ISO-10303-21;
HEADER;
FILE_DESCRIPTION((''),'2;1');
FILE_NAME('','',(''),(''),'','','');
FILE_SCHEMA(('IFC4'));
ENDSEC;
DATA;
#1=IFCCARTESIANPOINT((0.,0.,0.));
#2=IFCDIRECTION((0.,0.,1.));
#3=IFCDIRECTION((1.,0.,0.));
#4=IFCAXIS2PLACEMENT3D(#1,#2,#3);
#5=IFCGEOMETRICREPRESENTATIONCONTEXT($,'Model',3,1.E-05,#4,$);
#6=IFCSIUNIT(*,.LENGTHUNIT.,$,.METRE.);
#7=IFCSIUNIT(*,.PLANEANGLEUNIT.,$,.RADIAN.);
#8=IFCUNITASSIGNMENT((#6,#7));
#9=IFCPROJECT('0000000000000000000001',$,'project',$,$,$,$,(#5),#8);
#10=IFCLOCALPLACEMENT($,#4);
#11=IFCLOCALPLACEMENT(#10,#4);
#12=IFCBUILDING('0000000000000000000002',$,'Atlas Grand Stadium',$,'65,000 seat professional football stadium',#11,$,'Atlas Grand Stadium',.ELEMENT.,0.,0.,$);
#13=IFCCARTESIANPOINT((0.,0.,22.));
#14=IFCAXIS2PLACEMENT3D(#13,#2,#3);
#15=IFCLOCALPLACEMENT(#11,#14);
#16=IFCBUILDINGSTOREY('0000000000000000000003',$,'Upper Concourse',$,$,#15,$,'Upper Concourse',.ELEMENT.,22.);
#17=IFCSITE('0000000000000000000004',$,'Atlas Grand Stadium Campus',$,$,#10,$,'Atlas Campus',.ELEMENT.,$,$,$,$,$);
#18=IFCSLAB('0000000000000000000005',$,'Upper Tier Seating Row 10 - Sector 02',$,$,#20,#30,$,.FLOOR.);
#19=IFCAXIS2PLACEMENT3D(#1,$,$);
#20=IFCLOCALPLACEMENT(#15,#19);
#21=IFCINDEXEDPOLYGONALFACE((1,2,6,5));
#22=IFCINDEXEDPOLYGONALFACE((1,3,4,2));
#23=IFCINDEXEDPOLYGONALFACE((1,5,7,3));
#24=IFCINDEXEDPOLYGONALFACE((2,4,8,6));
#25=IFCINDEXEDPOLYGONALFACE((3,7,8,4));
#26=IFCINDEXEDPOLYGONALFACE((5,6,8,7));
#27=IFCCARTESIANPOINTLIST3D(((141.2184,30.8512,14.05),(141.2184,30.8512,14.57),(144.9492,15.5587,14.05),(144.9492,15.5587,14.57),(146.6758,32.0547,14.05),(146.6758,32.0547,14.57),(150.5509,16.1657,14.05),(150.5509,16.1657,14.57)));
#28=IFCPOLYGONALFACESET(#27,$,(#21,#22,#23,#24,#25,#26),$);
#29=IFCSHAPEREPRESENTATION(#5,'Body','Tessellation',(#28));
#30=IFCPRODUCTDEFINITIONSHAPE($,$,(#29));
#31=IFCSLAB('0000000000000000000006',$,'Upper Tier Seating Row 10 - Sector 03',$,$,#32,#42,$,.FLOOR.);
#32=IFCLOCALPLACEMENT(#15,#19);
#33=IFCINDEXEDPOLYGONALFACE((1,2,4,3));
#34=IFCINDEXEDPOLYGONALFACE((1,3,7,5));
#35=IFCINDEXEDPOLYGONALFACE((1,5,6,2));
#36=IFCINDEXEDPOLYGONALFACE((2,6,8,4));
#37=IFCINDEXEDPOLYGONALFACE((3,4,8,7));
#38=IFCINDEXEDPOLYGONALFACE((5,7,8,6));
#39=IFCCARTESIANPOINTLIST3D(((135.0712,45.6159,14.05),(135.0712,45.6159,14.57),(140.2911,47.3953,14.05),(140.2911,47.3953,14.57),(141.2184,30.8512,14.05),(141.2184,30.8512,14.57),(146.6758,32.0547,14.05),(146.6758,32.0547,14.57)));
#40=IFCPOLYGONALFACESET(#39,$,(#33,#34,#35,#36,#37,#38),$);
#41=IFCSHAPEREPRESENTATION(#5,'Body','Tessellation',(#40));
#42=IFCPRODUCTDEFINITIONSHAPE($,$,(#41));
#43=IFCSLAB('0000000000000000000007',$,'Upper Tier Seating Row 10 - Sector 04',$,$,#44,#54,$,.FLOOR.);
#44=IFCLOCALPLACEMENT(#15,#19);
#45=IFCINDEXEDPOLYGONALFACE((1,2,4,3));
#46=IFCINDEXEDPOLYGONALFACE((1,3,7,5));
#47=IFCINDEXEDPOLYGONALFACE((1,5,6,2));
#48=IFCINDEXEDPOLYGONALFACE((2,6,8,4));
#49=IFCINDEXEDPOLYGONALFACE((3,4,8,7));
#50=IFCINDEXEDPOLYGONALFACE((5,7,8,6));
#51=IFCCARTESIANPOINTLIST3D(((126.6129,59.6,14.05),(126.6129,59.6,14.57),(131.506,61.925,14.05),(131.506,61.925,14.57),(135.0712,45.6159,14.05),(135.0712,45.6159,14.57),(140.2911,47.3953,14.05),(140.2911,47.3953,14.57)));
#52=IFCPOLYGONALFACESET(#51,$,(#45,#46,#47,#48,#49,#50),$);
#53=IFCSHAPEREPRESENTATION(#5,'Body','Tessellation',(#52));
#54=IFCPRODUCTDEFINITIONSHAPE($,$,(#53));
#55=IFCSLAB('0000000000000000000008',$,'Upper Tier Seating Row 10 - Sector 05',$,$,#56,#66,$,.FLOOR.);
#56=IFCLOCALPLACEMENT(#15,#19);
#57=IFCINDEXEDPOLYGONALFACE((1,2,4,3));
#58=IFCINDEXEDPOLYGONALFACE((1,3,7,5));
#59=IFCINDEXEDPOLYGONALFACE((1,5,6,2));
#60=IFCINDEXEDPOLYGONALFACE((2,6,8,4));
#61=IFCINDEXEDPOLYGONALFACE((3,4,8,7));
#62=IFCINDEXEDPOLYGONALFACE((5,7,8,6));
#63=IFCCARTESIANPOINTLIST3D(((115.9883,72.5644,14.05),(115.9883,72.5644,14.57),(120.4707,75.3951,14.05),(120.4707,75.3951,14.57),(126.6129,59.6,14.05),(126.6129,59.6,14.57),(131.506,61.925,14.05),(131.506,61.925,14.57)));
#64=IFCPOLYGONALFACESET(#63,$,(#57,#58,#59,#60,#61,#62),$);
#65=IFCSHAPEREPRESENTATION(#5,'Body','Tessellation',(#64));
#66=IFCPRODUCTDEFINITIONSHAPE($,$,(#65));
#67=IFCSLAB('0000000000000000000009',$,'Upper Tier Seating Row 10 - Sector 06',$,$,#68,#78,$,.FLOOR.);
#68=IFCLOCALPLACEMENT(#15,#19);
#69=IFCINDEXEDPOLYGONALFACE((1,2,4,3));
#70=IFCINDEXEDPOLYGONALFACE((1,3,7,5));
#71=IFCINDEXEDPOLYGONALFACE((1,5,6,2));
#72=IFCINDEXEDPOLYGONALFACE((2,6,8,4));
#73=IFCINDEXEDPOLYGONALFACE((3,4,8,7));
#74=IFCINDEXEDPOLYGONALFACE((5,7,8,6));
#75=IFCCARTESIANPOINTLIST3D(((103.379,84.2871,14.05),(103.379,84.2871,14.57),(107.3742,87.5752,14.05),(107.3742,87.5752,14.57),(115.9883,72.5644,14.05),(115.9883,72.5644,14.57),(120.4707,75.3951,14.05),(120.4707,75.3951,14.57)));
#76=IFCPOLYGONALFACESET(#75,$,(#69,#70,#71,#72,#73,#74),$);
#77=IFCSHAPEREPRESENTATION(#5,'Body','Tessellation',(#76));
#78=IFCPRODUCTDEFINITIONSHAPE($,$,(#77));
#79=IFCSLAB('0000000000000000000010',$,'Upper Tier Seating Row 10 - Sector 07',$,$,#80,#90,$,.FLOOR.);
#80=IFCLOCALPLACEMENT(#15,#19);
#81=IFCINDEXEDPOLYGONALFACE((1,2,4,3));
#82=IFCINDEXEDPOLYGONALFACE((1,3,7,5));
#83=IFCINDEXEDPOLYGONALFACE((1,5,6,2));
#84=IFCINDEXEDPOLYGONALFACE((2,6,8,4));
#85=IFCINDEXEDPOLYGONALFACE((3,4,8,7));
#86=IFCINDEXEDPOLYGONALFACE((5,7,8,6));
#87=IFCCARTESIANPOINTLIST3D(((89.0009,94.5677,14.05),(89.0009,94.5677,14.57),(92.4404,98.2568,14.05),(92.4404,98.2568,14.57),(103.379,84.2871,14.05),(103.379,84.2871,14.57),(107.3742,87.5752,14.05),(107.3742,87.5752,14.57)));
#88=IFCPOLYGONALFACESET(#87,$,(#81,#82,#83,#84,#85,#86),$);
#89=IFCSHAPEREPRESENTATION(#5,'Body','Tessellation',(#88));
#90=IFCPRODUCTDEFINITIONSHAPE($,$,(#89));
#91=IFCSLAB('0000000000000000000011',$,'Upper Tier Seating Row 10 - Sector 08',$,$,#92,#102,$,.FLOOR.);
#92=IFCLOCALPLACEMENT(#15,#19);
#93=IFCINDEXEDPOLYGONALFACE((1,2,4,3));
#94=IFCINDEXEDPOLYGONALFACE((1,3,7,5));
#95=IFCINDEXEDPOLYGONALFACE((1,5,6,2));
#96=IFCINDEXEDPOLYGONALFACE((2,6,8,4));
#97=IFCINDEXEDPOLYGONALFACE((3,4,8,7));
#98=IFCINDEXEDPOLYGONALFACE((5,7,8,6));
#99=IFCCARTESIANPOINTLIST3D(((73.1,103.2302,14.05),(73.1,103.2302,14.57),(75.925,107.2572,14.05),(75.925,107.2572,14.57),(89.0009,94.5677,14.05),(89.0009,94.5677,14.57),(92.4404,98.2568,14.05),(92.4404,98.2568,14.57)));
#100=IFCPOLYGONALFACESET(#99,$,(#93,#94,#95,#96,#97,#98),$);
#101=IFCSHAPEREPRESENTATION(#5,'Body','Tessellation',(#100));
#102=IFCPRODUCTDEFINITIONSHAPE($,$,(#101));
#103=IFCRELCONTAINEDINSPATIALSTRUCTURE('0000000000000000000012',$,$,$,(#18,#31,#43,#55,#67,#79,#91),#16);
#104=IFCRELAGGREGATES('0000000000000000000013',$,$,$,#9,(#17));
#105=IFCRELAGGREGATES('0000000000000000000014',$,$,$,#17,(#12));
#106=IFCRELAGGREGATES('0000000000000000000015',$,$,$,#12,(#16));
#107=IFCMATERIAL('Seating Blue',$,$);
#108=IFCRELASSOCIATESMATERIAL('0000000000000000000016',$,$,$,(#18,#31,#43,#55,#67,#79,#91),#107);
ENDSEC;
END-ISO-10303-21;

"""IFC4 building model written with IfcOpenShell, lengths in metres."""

from ifc_helpers import new_model, si_unit, frame, origin_with_axes, place, context, project, spatial, polyline, outline, extrude, material, element, save


model = new_model("IFC4")

# Units and contexts
model_context = context("Model", 3, precision=1e-05, world=origin_with_axes())
ifc_project = project(units=[si_unit("LENGTHUNIT", "METRE"), si_unit("PLANEANGLEUNIT", "RADIAN")], contexts=[model_context])

# Site, building, storey
site_placement = place(None, origin_with_axes())
site = spatial("IfcSite", under=ifc_project, at=site_placement, Name="Atlas Grand Stadium Campus", LongName="Atlas Campus", CompositionType="ELEMENT")
building_placement = place(site_placement, origin_with_axes())
building = spatial("IfcBuilding", under=site, at=building_placement, Name="Atlas Grand Stadium", ObjectType="65,000 seat professional football stadium", LongName="Atlas Grand Stadium", CompositionType="ELEMENT", ElevationOfRefHeight=0.0, ElevationOfTerrain=0.0)
storey_placement = place(building_placement, frame((0.0, 0.0, 22.0), z_axis=(0.0, 0.0, 1.0), x_axis=(1.0, 0.0, 0.0)))
storey = spatial("IfcBuildingStorey", under=building, at=storey_placement, Name="Upper Concourse", LongName="Upper Concourse", CompositionType="ELEMENT", Elevation=22.0)

# Slabs
ifc_material_1 = material(Name="Seating Blue")
slab_1_placement = place(storey_placement, frame((0.0, 0.0, 14.05), z_axis=(0.0, 0.0, 1.0), x_axis=(1.0, 0.0, 0.0)))
element("IfcSlab", 1, at=slab_1_placement, inside=storey, material=ifc_material_1, Name="Upper Tier Seating Row 10 - Sector 02", PredefinedType="FLOOR", context=model_context, shape_type="SweptSolid", body=[
    extrude(outline(polyline([(150.5509, 16.1657), (146.6758, 32.0547), (141.2184, 30.8512), (144.9492, 15.5587), (150.5509, 16.1657)])), origin_with_axes(), (0.0, 0.0, 1.0), 0.52),
])
slab_2_placement = place(storey_placement, frame((0.0, 0.0, 14.05), z_axis=(0.0, 0.0, 1.0), x_axis=(1.0, 0.0, 0.0)))
element("IfcSlab", 2, at=slab_2_placement, inside=storey, material=ifc_material_1, Name="Upper Tier Seating Row 10 - Sector 03", PredefinedType="FLOOR", context=model_context, shape_type="SweptSolid", body=[
    extrude(outline(polyline([(146.6758, 32.0547), (140.2911, 47.3953), (135.0712, 45.6159), (141.2184, 30.8512), (146.6758, 32.0547)])), origin_with_axes(), (0.0, 0.0, 1.0), 0.52),
])
slab_3_placement = place(storey_placement, frame((0.0, 0.0, 14.05), z_axis=(0.0, 0.0, 1.0), x_axis=(1.0, 0.0, 0.0)))
element("IfcSlab", 3, at=slab_3_placement, inside=storey, material=ifc_material_1, Name="Upper Tier Seating Row 10 - Sector 04", PredefinedType="FLOOR", context=model_context, shape_type="SweptSolid", body=[
    extrude(outline(polyline([(140.2911, 47.3953), (131.506, 61.925), (126.6129, 59.6), (135.0712, 45.6159), (140.2911, 47.3953)])), origin_with_axes(), (0.0, 0.0, 1.0), 0.52),
])
slab_4_placement = place(storey_placement, frame((0.0, 0.0, 14.05), z_axis=(0.0, 0.0, 1.0), x_axis=(1.0, 0.0, 0.0)))
element("IfcSlab", 4, at=slab_4_placement, inside=storey, material=ifc_material_1, Name="Upper Tier Seating Row 10 - Sector 05", PredefinedType="FLOOR", context=model_context, shape_type="SweptSolid", body=[
    extrude(outline(polyline([(131.506, 61.925), (120.4707, 75.3951), (115.9883, 72.5644), (126.6129, 59.6), (131.506, 61.925)])), origin_with_axes(), (0.0, 0.0, 1.0), 0.52),
])
slab_5_placement = place(storey_placement, frame((0.0, 0.0, 14.05), z_axis=(0.0, 0.0, 1.0), x_axis=(1.0, 0.0, 0.0)))
element("IfcSlab", 5, at=slab_5_placement, inside=storey, material=ifc_material_1, Name="Upper Tier Seating Row 10 - Sector 06", PredefinedType="FLOOR", context=model_context, shape_type="SweptSolid", body=[
    extrude(outline(polyline([(120.4707, 75.3951), (107.3742, 87.5752), (103.379, 84.2871), (115.9883, 72.5644), (120.4707, 75.3951)])), origin_with_axes(), (0.0, 0.0, 1.0), 0.52),
])
slab_6_placement = place(storey_placement, frame((0.0, 0.0, 14.05), z_axis=(0.0, 0.0, 1.0), x_axis=(1.0, 0.0, 0.0)))
element("IfcSlab", 6, at=slab_6_placement, inside=storey, material=ifc_material_1, Name="Upper Tier Seating Row 10 - Sector 07", PredefinedType="FLOOR", context=model_context, shape_type="SweptSolid", body=[
    extrude(outline(polyline([(107.3742, 87.5752), (92.4404, 98.2568), (89.0009, 94.5677), (103.379, 84.2871), (107.3742, 87.5752)])), origin_with_axes(), (0.0, 0.0, 1.0), 0.52),
])
slab_7_placement = place(storey_placement, frame((0.0, 0.0, 14.05), z_axis=(0.0, 0.0, 1.0), x_axis=(1.0, 0.0, 0.0)))
element("IfcSlab", 7, at=slab_7_placement, inside=storey, material=ifc_material_1, Name="Upper Tier Seating Row 10 - Sector 08", PredefinedType="FLOOR", context=model_context, shape_type="SweptSolid", body=[
    extrude(outline(polyline([(92.4404, 98.2568), (75.925, 107.2572), (73.1, 103.2302), (89.0009, 94.5677), (92.4404, 98.2568)])), origin_with_axes(), (0.0, 0.0, 1.0), 0.52),
])

save(model, "model.ifc")
